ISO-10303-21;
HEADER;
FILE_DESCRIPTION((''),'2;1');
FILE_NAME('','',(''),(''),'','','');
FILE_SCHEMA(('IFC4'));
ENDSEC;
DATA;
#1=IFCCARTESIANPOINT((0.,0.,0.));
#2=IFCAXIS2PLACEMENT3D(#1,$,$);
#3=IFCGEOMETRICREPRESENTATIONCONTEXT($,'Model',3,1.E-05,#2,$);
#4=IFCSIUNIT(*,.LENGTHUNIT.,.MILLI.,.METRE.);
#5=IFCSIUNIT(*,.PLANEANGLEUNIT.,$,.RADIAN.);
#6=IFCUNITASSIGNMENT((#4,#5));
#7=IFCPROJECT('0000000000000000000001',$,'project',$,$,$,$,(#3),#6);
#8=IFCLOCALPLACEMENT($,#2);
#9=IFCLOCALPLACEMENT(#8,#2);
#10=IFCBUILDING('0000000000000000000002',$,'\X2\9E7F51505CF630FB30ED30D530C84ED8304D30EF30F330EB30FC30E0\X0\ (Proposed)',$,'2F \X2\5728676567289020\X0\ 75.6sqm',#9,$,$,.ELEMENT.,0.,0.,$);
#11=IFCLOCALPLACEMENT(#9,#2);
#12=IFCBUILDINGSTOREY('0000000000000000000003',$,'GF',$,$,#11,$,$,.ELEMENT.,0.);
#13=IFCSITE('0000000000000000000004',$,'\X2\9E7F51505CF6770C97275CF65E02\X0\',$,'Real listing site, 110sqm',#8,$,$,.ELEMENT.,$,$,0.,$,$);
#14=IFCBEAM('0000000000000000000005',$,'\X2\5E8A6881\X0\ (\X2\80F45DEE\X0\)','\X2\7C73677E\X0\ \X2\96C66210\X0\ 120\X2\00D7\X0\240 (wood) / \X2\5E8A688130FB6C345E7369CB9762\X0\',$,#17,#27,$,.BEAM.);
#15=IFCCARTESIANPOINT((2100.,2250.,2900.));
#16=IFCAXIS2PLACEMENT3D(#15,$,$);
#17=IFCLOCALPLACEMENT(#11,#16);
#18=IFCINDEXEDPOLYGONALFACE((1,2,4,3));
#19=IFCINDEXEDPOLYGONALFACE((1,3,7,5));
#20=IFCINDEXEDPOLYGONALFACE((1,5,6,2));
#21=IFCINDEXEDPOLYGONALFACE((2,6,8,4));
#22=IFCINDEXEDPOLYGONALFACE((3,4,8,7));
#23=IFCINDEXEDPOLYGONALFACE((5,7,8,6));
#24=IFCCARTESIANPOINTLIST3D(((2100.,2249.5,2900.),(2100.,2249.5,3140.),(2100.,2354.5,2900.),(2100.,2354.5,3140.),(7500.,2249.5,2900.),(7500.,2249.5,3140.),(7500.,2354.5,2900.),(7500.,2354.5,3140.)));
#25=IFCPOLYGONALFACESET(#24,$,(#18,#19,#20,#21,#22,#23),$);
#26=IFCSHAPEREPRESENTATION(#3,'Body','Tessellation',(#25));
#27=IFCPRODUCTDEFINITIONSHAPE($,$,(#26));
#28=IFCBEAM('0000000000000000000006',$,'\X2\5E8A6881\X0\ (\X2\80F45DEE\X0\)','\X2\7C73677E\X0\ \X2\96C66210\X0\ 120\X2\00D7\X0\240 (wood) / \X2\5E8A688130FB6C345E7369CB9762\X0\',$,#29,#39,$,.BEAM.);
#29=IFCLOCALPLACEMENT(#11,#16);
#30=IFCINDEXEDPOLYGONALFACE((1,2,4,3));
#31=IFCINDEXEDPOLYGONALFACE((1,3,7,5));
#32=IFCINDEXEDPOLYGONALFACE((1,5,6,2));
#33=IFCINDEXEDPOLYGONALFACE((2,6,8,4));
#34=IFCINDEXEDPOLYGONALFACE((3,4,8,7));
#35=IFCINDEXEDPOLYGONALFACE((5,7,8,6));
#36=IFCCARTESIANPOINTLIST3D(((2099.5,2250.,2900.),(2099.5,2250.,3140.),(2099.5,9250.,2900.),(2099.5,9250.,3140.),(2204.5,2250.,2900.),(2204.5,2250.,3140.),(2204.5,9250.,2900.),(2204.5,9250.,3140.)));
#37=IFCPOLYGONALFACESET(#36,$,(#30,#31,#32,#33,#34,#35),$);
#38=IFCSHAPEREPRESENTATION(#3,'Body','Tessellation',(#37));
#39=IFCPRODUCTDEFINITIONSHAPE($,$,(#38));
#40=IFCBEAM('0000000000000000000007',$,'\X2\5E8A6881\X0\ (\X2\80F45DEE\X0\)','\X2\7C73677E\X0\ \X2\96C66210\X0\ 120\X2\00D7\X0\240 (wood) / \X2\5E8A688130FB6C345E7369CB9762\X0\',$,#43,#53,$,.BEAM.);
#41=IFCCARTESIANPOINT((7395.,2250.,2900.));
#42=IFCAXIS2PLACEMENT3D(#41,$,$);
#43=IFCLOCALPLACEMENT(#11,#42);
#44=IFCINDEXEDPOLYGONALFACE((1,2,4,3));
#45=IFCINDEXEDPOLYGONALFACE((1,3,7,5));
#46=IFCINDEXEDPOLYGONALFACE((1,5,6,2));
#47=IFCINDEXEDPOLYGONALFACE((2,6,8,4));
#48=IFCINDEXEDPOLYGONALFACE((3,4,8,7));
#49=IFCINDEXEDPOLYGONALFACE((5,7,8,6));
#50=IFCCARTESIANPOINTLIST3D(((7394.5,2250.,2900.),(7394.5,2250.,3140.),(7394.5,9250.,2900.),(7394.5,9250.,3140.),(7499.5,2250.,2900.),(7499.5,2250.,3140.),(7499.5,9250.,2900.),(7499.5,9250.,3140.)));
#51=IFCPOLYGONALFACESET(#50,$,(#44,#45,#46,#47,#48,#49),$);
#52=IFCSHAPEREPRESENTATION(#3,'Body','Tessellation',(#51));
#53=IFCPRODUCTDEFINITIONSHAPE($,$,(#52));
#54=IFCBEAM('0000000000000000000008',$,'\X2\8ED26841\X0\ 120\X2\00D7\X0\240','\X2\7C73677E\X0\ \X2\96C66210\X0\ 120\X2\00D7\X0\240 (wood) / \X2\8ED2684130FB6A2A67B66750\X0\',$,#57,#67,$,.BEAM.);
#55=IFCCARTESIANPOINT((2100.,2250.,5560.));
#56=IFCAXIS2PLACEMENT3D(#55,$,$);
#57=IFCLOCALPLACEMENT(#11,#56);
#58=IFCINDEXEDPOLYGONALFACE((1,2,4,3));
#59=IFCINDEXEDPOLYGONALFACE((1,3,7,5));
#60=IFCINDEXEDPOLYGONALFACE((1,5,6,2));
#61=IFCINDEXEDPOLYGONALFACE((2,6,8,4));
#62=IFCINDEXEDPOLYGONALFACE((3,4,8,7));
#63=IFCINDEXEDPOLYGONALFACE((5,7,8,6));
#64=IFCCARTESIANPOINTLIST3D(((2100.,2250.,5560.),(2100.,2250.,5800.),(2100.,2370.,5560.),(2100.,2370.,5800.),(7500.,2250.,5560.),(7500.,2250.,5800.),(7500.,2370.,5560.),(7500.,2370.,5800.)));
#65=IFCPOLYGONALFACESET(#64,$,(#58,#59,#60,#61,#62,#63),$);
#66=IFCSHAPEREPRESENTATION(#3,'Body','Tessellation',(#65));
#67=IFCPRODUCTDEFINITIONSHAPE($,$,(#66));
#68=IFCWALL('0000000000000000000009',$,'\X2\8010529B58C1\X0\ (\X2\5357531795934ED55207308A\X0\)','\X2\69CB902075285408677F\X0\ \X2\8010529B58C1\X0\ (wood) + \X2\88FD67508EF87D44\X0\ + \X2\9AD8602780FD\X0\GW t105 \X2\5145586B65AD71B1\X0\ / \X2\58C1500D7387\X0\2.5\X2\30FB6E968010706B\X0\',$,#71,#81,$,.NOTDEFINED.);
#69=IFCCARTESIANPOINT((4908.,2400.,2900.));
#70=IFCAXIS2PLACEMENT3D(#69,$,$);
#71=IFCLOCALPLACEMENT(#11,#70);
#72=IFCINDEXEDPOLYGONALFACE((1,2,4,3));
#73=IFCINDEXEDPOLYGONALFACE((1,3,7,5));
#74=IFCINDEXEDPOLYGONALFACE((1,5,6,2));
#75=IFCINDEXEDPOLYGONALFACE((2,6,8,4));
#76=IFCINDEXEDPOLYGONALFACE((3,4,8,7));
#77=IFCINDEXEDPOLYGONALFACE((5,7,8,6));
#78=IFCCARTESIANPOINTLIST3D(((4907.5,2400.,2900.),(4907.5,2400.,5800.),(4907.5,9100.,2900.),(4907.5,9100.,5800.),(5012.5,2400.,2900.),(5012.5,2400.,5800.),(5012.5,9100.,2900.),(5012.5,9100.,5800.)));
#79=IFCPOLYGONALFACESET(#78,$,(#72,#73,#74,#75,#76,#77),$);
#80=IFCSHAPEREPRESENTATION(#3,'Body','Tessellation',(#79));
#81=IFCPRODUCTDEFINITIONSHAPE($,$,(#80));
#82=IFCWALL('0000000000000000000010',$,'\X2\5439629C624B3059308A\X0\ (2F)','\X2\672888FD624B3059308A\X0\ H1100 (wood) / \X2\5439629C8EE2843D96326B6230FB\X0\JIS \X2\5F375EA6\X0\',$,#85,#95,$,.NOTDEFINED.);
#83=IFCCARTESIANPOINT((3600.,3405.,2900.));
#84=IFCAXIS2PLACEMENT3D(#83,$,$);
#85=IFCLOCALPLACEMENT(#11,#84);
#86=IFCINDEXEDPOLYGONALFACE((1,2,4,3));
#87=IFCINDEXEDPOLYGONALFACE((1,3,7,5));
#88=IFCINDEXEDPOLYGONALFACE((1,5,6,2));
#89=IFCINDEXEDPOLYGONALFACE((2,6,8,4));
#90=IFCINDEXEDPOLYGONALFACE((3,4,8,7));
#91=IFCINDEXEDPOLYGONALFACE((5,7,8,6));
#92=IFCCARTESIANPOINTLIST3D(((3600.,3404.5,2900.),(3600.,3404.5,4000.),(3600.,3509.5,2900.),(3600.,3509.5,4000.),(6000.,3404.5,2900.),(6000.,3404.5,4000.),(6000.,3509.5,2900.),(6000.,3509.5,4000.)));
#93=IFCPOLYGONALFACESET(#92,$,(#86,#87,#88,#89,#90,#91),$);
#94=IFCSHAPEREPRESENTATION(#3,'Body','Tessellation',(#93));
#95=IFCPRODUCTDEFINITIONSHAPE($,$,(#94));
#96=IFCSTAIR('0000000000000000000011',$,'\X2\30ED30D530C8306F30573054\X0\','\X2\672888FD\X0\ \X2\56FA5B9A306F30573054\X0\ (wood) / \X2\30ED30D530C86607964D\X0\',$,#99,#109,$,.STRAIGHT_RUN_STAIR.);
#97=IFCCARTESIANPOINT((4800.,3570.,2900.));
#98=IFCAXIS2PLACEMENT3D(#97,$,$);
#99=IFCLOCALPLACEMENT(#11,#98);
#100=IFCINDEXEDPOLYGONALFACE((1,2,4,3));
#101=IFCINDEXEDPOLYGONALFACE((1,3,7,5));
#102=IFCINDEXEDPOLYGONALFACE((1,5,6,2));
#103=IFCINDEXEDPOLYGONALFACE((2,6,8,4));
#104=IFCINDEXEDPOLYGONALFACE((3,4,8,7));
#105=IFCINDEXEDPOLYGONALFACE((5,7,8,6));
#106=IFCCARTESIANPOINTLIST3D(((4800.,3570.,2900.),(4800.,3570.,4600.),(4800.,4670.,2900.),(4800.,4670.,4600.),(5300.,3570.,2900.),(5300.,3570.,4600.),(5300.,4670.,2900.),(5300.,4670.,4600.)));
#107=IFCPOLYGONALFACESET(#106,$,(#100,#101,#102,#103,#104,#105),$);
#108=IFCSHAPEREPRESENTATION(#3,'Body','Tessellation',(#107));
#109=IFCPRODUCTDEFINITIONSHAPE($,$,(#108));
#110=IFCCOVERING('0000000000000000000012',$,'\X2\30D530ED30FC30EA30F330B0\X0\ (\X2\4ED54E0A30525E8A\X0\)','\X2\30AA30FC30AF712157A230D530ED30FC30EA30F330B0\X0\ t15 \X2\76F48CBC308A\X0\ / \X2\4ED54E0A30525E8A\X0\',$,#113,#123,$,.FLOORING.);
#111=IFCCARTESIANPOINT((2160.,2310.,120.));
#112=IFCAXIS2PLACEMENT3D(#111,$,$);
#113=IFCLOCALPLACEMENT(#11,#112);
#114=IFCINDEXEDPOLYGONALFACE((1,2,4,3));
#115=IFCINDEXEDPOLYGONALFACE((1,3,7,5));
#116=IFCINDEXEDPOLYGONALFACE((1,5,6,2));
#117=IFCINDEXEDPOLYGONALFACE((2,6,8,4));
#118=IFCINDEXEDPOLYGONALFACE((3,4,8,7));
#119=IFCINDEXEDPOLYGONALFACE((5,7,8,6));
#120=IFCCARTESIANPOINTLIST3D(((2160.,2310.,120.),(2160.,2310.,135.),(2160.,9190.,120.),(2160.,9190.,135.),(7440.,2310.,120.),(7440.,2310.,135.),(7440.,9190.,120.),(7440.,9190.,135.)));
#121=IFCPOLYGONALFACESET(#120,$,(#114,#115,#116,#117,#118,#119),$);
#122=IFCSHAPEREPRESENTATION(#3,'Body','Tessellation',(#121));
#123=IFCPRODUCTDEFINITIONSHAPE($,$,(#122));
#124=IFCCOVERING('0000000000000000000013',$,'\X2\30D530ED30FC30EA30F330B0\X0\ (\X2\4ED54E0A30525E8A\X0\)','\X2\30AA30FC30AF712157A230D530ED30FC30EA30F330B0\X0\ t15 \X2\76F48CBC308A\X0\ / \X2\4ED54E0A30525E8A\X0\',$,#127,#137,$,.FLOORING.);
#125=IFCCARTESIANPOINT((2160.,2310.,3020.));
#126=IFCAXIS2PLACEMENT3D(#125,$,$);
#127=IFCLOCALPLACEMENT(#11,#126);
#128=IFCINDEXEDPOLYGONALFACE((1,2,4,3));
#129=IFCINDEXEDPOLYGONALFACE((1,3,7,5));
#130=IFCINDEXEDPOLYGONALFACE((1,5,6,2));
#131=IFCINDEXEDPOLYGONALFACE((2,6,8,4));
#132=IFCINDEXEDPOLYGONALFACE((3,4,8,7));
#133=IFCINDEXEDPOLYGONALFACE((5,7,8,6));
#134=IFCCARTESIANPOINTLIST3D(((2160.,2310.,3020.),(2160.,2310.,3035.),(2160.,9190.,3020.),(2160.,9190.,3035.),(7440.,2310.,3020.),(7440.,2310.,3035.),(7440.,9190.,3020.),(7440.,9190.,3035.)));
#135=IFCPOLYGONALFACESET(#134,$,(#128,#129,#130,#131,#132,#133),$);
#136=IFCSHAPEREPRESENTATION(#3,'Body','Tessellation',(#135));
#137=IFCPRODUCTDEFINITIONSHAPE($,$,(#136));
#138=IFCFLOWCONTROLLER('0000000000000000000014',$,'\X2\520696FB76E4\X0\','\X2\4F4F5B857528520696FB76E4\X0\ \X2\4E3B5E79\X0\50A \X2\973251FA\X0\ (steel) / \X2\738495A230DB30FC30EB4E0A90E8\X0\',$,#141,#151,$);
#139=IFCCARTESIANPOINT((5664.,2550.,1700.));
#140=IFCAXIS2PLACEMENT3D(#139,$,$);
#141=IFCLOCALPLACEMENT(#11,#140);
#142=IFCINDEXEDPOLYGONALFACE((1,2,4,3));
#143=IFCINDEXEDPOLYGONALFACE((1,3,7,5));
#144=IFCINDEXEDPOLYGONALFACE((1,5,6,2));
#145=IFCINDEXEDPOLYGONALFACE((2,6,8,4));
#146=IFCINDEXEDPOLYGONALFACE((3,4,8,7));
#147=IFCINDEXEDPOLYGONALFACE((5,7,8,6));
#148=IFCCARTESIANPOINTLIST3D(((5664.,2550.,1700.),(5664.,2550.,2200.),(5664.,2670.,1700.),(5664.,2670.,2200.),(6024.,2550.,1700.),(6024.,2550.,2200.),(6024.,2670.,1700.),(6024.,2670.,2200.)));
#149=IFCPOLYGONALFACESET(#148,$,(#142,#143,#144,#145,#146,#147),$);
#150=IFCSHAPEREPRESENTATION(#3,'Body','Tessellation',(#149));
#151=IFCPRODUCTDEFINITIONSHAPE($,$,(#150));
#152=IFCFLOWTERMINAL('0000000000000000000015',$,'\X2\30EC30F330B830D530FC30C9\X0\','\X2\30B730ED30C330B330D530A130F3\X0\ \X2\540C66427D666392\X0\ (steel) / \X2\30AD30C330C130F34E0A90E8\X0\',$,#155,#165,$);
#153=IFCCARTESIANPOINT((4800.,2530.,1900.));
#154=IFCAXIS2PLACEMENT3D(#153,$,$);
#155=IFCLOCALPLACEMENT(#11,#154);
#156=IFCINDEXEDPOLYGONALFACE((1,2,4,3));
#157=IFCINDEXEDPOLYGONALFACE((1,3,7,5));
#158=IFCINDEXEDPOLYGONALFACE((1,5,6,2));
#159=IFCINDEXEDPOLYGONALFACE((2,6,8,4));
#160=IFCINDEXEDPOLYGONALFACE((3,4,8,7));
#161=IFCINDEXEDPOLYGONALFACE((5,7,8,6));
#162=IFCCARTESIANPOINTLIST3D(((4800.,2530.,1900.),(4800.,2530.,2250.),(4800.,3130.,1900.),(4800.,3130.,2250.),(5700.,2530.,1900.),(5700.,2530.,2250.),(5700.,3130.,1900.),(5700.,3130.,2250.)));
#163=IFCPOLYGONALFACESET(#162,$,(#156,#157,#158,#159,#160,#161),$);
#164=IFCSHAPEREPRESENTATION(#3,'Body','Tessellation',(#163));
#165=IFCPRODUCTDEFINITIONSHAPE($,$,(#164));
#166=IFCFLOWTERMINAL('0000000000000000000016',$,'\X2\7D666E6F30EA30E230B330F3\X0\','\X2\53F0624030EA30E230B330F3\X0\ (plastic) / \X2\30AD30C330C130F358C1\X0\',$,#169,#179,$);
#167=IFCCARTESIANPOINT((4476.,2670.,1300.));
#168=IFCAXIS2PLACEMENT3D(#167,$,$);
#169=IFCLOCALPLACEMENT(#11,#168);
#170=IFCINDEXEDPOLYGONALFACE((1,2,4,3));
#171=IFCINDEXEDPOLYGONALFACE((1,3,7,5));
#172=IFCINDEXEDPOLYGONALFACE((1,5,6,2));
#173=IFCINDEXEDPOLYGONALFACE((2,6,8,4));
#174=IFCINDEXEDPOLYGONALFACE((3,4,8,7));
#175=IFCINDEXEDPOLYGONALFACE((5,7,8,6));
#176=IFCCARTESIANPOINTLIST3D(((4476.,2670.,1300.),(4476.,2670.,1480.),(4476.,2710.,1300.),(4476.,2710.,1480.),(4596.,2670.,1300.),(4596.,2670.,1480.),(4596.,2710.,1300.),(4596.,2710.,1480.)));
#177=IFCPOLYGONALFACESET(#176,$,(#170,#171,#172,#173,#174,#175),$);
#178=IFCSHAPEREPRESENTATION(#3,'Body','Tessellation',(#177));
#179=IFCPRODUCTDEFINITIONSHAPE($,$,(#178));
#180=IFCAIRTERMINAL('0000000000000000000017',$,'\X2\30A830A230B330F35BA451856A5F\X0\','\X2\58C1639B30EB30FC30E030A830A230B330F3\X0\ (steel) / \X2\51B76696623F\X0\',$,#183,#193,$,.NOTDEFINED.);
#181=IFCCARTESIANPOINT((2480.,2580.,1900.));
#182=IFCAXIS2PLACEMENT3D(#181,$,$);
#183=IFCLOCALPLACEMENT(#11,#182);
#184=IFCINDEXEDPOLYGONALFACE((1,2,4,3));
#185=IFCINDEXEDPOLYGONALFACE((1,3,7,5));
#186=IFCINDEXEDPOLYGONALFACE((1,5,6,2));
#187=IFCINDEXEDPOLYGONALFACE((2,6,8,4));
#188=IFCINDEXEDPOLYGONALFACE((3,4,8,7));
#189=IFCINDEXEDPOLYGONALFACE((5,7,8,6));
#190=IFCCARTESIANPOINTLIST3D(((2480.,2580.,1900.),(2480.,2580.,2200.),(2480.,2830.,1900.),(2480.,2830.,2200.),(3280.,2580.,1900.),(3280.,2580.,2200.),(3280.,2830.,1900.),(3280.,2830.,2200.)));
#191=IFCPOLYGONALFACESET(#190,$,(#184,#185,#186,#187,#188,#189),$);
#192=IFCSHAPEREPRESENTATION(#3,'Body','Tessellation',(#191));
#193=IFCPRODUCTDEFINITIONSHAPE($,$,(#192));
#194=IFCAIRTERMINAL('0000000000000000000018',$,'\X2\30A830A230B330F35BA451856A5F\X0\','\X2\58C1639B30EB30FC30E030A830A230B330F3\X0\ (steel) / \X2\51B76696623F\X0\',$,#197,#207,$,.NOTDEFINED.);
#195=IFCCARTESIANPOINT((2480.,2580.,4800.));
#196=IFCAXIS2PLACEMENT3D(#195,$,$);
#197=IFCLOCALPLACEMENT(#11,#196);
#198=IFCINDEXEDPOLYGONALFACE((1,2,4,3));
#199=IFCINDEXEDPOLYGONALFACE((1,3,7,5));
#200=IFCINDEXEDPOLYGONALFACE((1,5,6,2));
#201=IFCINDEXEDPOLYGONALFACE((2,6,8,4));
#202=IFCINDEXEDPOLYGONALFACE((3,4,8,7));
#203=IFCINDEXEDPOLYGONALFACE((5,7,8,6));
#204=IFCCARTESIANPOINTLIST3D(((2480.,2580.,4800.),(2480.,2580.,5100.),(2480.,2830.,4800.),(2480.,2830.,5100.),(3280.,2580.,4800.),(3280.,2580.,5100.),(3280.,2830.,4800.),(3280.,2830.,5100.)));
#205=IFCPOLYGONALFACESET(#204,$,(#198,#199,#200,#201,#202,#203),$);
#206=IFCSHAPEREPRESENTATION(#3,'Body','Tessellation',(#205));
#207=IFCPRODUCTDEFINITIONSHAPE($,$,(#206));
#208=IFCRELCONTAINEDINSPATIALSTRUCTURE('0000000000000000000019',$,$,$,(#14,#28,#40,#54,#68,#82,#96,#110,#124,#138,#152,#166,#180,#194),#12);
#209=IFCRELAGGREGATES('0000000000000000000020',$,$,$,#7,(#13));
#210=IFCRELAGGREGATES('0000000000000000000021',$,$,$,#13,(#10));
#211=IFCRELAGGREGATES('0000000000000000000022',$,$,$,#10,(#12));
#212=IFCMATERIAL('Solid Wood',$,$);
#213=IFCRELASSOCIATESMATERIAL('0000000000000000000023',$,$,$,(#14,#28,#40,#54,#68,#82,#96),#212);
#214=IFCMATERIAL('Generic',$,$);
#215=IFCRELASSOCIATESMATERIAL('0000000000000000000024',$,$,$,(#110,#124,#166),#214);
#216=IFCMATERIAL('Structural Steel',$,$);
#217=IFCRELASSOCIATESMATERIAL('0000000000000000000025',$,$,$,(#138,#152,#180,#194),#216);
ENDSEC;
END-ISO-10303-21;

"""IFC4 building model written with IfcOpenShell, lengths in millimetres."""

from ifc_helpers import new_model, si_unit, frame, frame_2d, origin, place, context, project, spatial, rectangle, extrude, material, element, save


model = new_model("IFC4")

# Units and contexts
model_context = context("Model", 3, precision=1e-05, world=origin())
ifc_project = project(units=[si_unit("LENGTHUNIT", "METRE", prefix="MILLI"), si_unit("PLANEANGLEUNIT", "RADIAN")], contexts=[model_context])

# Site, building, storey
site_placement = place(None, origin())
site = spatial("IfcSite", under=ifc_project, at=site_placement, Name="鹿児島県霧島市", ObjectType="Real listing site, 110sqm", CompositionType="ELEMENT", RefElevation=0.0)
building_placement = place(site_placement, origin())
building = spatial("IfcBuilding", under=site, at=building_placement, Name="鹿児島・ロフト付きワンルーム (Proposed)", ObjectType="2F 在来木造 75.6sqm", CompositionType="ELEMENT", ElevationOfRefHeight=0.0, ElevationOfTerrain=0.0)
storey_placement = place(building_placement, origin())
storey = spatial("IfcBuildingStorey", under=building, at=storey_placement, Name="GF", CompositionType="ELEMENT", Elevation=0.0)

# Shared definitions
ifc_material_1 = material(Name="Solid Wood")

# Beams
beam_1_placement = place(storey_placement, frame((2100.0, 2250.0, 2900.0)))
element("IfcBeam", 1, at=beam_1_placement, inside=storey, material=ifc_material_1, Name="床梁 (胴差)", Description="米松 集成 120×240 (wood) / 床梁・水平構面", PredefinedType="BEAM", context=model_context, shape_type="SweptSolid", body=[
    extrude(rectangle(XDim=5400.0, YDim=105.0, at=frame_2d((2700.0, 52.0))), frame((2100.0, 2250.0, 2900.0)), (0.0, 0.0, 1.0), 240.0),
])
beam_2_placement = place(storey_placement, frame((2100.0, 2250.0, 2900.0)))
element("IfcBeam", 2, at=beam_2_placement, inside=storey, material=ifc_material_1, Name="床梁 (胴差)", Description="米松 集成 120×240 (wood) / 床梁・水平構面", PredefinedType="BEAM", context=model_context, shape_type="SweptSolid", body=[
    extrude(rectangle(XDim=105.0, YDim=7000.0, at=frame_2d((52.0, 3500.0))), frame((2100.0, 2250.0, 2900.0)), (0.0, 0.0, 1.0), 240.0),
])
beam_3_placement = place(storey_placement, frame((7395.0, 2250.0, 2900.0)))
element("IfcBeam", 3, at=beam_3_placement, inside=storey, material=ifc_material_1, Name="床梁 (胴差)", Description="米松 集成 120×240 (wood) / 床梁・水平構面", PredefinedType="BEAM", context=model_context, shape_type="SweptSolid", body=[
    extrude(rectangle(XDim=105.0, YDim=7000.0, at=frame_2d((52.0, 3500.0))), frame((7395.0, 2250.0, 2900.0)), (0.0, 0.0, 1.0), 240.0),
])
beam_4_placement = place(storey_placement, frame((2100.0, 2250.0, 5560.0)))
element("IfcBeam", 4, at=beam_4_placement, inside=storey, material=ifc_material_1, Name="軒桁 120×240", Description="米松 集成 120×240 (wood) / 軒桁・横架材", PredefinedType="BEAM", context=model_context, shape_type="SweptSolid", body=[
    extrude(rectangle(XDim=5400.0, YDim=120.0, at=frame_2d((2700.0, 60.0))), frame((2100.0, 2250.0, 5560.0)), (0.0, 0.0, 1.0), 240.0),
])

# Walls
wall_1_placement = place(storey_placement, frame((4908.0, 2400.0, 2900.0)))
element("IfcWall", 5, at=wall_1_placement, inside=storey, material=ifc_material_1, Name="耐力壁 (南北間仕切り)", Description="構造用合板 耐力壁 (wood) + 製材軸組 + 高性能GW t105 充填断熱 / 壁倍率2.5・準耐火", PredefinedType="NOTDEFINED", context=model_context, shape_type="SweptSolid", body=[
    extrude(rectangle(XDim=105.0, YDim=6700.0, at=frame_2d((52.0, 3350.0))), frame((4908.0, 2400.0, 2900.0)), (0.0, 0.0, 1.0), 2900.0),
])
wall_2_placement = place(storey_placement, frame((3600.0, 3405.0, 2900.0)))
element("IfcWall", 6, at=wall_2_placement, inside=storey, material=ifc_material_1, Name="吹抜手すり (2F)", Description="木製手すり H1100 (wood) / 吹抜転落防止・JIS 強度", PredefinedType="NOTDEFINED", context=model_context, shape_type="SweptSolid", body=[
    extrude(rectangle(XDim=2400.0, YDim=105.0, at=frame_2d((1200.0, 52.0))), frame((3600.0, 3405.0, 2900.0)), (0.0, 0.0, 1.0), 1100.0),
])

# Stair
stair_1_placement = place(storey_placement, frame((4800.0, 3570.0, 2900.0)))
element("IfcStair", 7, at=stair_1_placement, inside=storey, material=ifc_material_1, Name="ロフトはしご", Description="木製 固定はしご (wood) / ロフト昇降", PredefinedType="STRAIGHT_RUN_STAIR", context=model_context, shape_type="SweptSolid", body=[
    extrude(rectangle(XDim=500.0, YDim=1100.0, at=frame_2d((250.0, 550.0))), frame((4800.0, 3570.0, 2900.0)), (0.0, 0.0, 1.0), 1700.0),
])

# Coverings
ifc_material_2 = material(Name="Generic")
covering_1_placement = place(storey_placement, frame((2160.0, 2310.0, 120.0)))
element("IfcCovering", 8, at=covering_1_placement, inside=storey, material=ifc_material_2, Name="フローリング (仕上げ床)", Description="オーク無垢フローリング t15 直貼り / 仕上げ床", PredefinedType="FLOORING", context=model_context, shape_type="SweptSolid", body=[
    extrude(rectangle(XDim=5280.0, YDim=6880.0, at=frame_2d((2640.0, 3440.0))), frame((2160.0, 2310.0, 120.0)), (0.0, 0.0, 1.0), 15.0),
])
covering_2_placement = place(storey_placement, frame((2160.0, 2310.0, 3020.0)))
element("IfcCovering", 9, at=covering_2_placement, inside=storey, material=ifc_material_2, Name="フローリング (仕上げ床)", Description="オーク無垢フローリング t15 直貼り / 仕上げ床", PredefinedType="FLOORING", context=model_context, shape_type="SweptSolid", body=[
    extrude(rectangle(XDim=5280.0, YDim=6880.0, at=frame_2d((2640.0, 3440.0))), frame((2160.0, 2310.0, 3020.0)), (0.0, 0.0, 1.0), 15.0),
])

# Flow controller
ifc_material_3 = material(Name="Structural Steel")
flow_controller_placement = place(storey_placement, frame((5664.0, 2550.0, 1700.0)))
element("IfcFlowController", 10, at=flow_controller_placement, inside=storey, material=ifc_material_3, Name="分電盤", Description="住宅用分電盤 主幹50A 露出 (steel) / 玄関ホール上部", context=model_context, shape_type="SweptSolid", body=[
    extrude(rectangle(XDim=360.0, YDim=120.0, at=frame_2d((180.0, 60.0))), frame((5664.0, 2550.0, 1700.0)), (0.0, 0.0, 1.0), 500.0),
])

# Flow terminals
flow_terminal_1_placement = place(storey_placement, frame((4800.0, 2530.0, 1900.0)))
element("IfcFlowTerminal", 11, at=flow_terminal_1_placement, inside=storey, material=ifc_material_3, Name="レンジフード", Description="シロッコファン 同時給排 (steel) / キッチン上部", context=model_context, shape_type="SweptSolid", body=[
    extrude(rectangle(XDim=900.0, YDim=600.0, at=frame_2d((450.0, 300.0))), frame((4800.0, 2530.0, 1900.0)), (0.0, 0.0, 1.0), 350.0),
])
flow_terminal_2_placement = place(storey_placement, frame((4476.0, 2670.0, 1300.0)))
element("IfcFlowTerminal", 12, at=flow_terminal_2_placement, inside=storey, material=ifc_material_2, Name="給湯リモコン", Description="台所リモコン (plastic) / キッチン壁", context=model_context, shape_type="SweptSolid", body=[
    extrude(rectangle(XDim=120.0, YDim=40.0, at=frame_2d((60.0, 20.0))), frame((4476.0, 2670.0, 1300.0)), (0.0, 0.0, 1.0), 180.0),
])

# Air terminals
air_terminal_1_placement = place(storey_placement, frame((2480.0, 2580.0, 1900.0)))
element("IfcAirTerminal", 13, at=air_terminal_1_placement, inside=storey, material=ifc_material_3, Name="エアコン室内機", Description="壁掛ルームエアコン (steel) / 冷暖房", PredefinedType="NOTDEFINED", context=model_context, shape_type="SweptSolid", body=[
    extrude(rectangle(XDim=800.0, YDim=250.0, at=frame_2d((400.0, 125.0))), frame((2480.0, 2580.0, 1900.0)), (0.0, 0.0, 1.0), 300.0),
])
air_terminal_2_placement = place(storey_placement, frame((2480.0, 2580.0, 4800.0)))
element("IfcAirTerminal", 14, at=air_terminal_2_placement, inside=storey, material=ifc_material_3, Name="エアコン室内機", Description="壁掛ルームエアコン (steel) / 冷暖房", PredefinedType="NOTDEFINED", context=model_context, shape_type="SweptSolid", body=[
    extrude(rectangle(XDim=800.0, YDim=250.0, at=frame_2d((400.0, 125.0))), frame((2480.0, 2580.0, 4800.0)), (0.0, 0.0, 1.0), 300.0),
])

save(model, "model.ifc")
